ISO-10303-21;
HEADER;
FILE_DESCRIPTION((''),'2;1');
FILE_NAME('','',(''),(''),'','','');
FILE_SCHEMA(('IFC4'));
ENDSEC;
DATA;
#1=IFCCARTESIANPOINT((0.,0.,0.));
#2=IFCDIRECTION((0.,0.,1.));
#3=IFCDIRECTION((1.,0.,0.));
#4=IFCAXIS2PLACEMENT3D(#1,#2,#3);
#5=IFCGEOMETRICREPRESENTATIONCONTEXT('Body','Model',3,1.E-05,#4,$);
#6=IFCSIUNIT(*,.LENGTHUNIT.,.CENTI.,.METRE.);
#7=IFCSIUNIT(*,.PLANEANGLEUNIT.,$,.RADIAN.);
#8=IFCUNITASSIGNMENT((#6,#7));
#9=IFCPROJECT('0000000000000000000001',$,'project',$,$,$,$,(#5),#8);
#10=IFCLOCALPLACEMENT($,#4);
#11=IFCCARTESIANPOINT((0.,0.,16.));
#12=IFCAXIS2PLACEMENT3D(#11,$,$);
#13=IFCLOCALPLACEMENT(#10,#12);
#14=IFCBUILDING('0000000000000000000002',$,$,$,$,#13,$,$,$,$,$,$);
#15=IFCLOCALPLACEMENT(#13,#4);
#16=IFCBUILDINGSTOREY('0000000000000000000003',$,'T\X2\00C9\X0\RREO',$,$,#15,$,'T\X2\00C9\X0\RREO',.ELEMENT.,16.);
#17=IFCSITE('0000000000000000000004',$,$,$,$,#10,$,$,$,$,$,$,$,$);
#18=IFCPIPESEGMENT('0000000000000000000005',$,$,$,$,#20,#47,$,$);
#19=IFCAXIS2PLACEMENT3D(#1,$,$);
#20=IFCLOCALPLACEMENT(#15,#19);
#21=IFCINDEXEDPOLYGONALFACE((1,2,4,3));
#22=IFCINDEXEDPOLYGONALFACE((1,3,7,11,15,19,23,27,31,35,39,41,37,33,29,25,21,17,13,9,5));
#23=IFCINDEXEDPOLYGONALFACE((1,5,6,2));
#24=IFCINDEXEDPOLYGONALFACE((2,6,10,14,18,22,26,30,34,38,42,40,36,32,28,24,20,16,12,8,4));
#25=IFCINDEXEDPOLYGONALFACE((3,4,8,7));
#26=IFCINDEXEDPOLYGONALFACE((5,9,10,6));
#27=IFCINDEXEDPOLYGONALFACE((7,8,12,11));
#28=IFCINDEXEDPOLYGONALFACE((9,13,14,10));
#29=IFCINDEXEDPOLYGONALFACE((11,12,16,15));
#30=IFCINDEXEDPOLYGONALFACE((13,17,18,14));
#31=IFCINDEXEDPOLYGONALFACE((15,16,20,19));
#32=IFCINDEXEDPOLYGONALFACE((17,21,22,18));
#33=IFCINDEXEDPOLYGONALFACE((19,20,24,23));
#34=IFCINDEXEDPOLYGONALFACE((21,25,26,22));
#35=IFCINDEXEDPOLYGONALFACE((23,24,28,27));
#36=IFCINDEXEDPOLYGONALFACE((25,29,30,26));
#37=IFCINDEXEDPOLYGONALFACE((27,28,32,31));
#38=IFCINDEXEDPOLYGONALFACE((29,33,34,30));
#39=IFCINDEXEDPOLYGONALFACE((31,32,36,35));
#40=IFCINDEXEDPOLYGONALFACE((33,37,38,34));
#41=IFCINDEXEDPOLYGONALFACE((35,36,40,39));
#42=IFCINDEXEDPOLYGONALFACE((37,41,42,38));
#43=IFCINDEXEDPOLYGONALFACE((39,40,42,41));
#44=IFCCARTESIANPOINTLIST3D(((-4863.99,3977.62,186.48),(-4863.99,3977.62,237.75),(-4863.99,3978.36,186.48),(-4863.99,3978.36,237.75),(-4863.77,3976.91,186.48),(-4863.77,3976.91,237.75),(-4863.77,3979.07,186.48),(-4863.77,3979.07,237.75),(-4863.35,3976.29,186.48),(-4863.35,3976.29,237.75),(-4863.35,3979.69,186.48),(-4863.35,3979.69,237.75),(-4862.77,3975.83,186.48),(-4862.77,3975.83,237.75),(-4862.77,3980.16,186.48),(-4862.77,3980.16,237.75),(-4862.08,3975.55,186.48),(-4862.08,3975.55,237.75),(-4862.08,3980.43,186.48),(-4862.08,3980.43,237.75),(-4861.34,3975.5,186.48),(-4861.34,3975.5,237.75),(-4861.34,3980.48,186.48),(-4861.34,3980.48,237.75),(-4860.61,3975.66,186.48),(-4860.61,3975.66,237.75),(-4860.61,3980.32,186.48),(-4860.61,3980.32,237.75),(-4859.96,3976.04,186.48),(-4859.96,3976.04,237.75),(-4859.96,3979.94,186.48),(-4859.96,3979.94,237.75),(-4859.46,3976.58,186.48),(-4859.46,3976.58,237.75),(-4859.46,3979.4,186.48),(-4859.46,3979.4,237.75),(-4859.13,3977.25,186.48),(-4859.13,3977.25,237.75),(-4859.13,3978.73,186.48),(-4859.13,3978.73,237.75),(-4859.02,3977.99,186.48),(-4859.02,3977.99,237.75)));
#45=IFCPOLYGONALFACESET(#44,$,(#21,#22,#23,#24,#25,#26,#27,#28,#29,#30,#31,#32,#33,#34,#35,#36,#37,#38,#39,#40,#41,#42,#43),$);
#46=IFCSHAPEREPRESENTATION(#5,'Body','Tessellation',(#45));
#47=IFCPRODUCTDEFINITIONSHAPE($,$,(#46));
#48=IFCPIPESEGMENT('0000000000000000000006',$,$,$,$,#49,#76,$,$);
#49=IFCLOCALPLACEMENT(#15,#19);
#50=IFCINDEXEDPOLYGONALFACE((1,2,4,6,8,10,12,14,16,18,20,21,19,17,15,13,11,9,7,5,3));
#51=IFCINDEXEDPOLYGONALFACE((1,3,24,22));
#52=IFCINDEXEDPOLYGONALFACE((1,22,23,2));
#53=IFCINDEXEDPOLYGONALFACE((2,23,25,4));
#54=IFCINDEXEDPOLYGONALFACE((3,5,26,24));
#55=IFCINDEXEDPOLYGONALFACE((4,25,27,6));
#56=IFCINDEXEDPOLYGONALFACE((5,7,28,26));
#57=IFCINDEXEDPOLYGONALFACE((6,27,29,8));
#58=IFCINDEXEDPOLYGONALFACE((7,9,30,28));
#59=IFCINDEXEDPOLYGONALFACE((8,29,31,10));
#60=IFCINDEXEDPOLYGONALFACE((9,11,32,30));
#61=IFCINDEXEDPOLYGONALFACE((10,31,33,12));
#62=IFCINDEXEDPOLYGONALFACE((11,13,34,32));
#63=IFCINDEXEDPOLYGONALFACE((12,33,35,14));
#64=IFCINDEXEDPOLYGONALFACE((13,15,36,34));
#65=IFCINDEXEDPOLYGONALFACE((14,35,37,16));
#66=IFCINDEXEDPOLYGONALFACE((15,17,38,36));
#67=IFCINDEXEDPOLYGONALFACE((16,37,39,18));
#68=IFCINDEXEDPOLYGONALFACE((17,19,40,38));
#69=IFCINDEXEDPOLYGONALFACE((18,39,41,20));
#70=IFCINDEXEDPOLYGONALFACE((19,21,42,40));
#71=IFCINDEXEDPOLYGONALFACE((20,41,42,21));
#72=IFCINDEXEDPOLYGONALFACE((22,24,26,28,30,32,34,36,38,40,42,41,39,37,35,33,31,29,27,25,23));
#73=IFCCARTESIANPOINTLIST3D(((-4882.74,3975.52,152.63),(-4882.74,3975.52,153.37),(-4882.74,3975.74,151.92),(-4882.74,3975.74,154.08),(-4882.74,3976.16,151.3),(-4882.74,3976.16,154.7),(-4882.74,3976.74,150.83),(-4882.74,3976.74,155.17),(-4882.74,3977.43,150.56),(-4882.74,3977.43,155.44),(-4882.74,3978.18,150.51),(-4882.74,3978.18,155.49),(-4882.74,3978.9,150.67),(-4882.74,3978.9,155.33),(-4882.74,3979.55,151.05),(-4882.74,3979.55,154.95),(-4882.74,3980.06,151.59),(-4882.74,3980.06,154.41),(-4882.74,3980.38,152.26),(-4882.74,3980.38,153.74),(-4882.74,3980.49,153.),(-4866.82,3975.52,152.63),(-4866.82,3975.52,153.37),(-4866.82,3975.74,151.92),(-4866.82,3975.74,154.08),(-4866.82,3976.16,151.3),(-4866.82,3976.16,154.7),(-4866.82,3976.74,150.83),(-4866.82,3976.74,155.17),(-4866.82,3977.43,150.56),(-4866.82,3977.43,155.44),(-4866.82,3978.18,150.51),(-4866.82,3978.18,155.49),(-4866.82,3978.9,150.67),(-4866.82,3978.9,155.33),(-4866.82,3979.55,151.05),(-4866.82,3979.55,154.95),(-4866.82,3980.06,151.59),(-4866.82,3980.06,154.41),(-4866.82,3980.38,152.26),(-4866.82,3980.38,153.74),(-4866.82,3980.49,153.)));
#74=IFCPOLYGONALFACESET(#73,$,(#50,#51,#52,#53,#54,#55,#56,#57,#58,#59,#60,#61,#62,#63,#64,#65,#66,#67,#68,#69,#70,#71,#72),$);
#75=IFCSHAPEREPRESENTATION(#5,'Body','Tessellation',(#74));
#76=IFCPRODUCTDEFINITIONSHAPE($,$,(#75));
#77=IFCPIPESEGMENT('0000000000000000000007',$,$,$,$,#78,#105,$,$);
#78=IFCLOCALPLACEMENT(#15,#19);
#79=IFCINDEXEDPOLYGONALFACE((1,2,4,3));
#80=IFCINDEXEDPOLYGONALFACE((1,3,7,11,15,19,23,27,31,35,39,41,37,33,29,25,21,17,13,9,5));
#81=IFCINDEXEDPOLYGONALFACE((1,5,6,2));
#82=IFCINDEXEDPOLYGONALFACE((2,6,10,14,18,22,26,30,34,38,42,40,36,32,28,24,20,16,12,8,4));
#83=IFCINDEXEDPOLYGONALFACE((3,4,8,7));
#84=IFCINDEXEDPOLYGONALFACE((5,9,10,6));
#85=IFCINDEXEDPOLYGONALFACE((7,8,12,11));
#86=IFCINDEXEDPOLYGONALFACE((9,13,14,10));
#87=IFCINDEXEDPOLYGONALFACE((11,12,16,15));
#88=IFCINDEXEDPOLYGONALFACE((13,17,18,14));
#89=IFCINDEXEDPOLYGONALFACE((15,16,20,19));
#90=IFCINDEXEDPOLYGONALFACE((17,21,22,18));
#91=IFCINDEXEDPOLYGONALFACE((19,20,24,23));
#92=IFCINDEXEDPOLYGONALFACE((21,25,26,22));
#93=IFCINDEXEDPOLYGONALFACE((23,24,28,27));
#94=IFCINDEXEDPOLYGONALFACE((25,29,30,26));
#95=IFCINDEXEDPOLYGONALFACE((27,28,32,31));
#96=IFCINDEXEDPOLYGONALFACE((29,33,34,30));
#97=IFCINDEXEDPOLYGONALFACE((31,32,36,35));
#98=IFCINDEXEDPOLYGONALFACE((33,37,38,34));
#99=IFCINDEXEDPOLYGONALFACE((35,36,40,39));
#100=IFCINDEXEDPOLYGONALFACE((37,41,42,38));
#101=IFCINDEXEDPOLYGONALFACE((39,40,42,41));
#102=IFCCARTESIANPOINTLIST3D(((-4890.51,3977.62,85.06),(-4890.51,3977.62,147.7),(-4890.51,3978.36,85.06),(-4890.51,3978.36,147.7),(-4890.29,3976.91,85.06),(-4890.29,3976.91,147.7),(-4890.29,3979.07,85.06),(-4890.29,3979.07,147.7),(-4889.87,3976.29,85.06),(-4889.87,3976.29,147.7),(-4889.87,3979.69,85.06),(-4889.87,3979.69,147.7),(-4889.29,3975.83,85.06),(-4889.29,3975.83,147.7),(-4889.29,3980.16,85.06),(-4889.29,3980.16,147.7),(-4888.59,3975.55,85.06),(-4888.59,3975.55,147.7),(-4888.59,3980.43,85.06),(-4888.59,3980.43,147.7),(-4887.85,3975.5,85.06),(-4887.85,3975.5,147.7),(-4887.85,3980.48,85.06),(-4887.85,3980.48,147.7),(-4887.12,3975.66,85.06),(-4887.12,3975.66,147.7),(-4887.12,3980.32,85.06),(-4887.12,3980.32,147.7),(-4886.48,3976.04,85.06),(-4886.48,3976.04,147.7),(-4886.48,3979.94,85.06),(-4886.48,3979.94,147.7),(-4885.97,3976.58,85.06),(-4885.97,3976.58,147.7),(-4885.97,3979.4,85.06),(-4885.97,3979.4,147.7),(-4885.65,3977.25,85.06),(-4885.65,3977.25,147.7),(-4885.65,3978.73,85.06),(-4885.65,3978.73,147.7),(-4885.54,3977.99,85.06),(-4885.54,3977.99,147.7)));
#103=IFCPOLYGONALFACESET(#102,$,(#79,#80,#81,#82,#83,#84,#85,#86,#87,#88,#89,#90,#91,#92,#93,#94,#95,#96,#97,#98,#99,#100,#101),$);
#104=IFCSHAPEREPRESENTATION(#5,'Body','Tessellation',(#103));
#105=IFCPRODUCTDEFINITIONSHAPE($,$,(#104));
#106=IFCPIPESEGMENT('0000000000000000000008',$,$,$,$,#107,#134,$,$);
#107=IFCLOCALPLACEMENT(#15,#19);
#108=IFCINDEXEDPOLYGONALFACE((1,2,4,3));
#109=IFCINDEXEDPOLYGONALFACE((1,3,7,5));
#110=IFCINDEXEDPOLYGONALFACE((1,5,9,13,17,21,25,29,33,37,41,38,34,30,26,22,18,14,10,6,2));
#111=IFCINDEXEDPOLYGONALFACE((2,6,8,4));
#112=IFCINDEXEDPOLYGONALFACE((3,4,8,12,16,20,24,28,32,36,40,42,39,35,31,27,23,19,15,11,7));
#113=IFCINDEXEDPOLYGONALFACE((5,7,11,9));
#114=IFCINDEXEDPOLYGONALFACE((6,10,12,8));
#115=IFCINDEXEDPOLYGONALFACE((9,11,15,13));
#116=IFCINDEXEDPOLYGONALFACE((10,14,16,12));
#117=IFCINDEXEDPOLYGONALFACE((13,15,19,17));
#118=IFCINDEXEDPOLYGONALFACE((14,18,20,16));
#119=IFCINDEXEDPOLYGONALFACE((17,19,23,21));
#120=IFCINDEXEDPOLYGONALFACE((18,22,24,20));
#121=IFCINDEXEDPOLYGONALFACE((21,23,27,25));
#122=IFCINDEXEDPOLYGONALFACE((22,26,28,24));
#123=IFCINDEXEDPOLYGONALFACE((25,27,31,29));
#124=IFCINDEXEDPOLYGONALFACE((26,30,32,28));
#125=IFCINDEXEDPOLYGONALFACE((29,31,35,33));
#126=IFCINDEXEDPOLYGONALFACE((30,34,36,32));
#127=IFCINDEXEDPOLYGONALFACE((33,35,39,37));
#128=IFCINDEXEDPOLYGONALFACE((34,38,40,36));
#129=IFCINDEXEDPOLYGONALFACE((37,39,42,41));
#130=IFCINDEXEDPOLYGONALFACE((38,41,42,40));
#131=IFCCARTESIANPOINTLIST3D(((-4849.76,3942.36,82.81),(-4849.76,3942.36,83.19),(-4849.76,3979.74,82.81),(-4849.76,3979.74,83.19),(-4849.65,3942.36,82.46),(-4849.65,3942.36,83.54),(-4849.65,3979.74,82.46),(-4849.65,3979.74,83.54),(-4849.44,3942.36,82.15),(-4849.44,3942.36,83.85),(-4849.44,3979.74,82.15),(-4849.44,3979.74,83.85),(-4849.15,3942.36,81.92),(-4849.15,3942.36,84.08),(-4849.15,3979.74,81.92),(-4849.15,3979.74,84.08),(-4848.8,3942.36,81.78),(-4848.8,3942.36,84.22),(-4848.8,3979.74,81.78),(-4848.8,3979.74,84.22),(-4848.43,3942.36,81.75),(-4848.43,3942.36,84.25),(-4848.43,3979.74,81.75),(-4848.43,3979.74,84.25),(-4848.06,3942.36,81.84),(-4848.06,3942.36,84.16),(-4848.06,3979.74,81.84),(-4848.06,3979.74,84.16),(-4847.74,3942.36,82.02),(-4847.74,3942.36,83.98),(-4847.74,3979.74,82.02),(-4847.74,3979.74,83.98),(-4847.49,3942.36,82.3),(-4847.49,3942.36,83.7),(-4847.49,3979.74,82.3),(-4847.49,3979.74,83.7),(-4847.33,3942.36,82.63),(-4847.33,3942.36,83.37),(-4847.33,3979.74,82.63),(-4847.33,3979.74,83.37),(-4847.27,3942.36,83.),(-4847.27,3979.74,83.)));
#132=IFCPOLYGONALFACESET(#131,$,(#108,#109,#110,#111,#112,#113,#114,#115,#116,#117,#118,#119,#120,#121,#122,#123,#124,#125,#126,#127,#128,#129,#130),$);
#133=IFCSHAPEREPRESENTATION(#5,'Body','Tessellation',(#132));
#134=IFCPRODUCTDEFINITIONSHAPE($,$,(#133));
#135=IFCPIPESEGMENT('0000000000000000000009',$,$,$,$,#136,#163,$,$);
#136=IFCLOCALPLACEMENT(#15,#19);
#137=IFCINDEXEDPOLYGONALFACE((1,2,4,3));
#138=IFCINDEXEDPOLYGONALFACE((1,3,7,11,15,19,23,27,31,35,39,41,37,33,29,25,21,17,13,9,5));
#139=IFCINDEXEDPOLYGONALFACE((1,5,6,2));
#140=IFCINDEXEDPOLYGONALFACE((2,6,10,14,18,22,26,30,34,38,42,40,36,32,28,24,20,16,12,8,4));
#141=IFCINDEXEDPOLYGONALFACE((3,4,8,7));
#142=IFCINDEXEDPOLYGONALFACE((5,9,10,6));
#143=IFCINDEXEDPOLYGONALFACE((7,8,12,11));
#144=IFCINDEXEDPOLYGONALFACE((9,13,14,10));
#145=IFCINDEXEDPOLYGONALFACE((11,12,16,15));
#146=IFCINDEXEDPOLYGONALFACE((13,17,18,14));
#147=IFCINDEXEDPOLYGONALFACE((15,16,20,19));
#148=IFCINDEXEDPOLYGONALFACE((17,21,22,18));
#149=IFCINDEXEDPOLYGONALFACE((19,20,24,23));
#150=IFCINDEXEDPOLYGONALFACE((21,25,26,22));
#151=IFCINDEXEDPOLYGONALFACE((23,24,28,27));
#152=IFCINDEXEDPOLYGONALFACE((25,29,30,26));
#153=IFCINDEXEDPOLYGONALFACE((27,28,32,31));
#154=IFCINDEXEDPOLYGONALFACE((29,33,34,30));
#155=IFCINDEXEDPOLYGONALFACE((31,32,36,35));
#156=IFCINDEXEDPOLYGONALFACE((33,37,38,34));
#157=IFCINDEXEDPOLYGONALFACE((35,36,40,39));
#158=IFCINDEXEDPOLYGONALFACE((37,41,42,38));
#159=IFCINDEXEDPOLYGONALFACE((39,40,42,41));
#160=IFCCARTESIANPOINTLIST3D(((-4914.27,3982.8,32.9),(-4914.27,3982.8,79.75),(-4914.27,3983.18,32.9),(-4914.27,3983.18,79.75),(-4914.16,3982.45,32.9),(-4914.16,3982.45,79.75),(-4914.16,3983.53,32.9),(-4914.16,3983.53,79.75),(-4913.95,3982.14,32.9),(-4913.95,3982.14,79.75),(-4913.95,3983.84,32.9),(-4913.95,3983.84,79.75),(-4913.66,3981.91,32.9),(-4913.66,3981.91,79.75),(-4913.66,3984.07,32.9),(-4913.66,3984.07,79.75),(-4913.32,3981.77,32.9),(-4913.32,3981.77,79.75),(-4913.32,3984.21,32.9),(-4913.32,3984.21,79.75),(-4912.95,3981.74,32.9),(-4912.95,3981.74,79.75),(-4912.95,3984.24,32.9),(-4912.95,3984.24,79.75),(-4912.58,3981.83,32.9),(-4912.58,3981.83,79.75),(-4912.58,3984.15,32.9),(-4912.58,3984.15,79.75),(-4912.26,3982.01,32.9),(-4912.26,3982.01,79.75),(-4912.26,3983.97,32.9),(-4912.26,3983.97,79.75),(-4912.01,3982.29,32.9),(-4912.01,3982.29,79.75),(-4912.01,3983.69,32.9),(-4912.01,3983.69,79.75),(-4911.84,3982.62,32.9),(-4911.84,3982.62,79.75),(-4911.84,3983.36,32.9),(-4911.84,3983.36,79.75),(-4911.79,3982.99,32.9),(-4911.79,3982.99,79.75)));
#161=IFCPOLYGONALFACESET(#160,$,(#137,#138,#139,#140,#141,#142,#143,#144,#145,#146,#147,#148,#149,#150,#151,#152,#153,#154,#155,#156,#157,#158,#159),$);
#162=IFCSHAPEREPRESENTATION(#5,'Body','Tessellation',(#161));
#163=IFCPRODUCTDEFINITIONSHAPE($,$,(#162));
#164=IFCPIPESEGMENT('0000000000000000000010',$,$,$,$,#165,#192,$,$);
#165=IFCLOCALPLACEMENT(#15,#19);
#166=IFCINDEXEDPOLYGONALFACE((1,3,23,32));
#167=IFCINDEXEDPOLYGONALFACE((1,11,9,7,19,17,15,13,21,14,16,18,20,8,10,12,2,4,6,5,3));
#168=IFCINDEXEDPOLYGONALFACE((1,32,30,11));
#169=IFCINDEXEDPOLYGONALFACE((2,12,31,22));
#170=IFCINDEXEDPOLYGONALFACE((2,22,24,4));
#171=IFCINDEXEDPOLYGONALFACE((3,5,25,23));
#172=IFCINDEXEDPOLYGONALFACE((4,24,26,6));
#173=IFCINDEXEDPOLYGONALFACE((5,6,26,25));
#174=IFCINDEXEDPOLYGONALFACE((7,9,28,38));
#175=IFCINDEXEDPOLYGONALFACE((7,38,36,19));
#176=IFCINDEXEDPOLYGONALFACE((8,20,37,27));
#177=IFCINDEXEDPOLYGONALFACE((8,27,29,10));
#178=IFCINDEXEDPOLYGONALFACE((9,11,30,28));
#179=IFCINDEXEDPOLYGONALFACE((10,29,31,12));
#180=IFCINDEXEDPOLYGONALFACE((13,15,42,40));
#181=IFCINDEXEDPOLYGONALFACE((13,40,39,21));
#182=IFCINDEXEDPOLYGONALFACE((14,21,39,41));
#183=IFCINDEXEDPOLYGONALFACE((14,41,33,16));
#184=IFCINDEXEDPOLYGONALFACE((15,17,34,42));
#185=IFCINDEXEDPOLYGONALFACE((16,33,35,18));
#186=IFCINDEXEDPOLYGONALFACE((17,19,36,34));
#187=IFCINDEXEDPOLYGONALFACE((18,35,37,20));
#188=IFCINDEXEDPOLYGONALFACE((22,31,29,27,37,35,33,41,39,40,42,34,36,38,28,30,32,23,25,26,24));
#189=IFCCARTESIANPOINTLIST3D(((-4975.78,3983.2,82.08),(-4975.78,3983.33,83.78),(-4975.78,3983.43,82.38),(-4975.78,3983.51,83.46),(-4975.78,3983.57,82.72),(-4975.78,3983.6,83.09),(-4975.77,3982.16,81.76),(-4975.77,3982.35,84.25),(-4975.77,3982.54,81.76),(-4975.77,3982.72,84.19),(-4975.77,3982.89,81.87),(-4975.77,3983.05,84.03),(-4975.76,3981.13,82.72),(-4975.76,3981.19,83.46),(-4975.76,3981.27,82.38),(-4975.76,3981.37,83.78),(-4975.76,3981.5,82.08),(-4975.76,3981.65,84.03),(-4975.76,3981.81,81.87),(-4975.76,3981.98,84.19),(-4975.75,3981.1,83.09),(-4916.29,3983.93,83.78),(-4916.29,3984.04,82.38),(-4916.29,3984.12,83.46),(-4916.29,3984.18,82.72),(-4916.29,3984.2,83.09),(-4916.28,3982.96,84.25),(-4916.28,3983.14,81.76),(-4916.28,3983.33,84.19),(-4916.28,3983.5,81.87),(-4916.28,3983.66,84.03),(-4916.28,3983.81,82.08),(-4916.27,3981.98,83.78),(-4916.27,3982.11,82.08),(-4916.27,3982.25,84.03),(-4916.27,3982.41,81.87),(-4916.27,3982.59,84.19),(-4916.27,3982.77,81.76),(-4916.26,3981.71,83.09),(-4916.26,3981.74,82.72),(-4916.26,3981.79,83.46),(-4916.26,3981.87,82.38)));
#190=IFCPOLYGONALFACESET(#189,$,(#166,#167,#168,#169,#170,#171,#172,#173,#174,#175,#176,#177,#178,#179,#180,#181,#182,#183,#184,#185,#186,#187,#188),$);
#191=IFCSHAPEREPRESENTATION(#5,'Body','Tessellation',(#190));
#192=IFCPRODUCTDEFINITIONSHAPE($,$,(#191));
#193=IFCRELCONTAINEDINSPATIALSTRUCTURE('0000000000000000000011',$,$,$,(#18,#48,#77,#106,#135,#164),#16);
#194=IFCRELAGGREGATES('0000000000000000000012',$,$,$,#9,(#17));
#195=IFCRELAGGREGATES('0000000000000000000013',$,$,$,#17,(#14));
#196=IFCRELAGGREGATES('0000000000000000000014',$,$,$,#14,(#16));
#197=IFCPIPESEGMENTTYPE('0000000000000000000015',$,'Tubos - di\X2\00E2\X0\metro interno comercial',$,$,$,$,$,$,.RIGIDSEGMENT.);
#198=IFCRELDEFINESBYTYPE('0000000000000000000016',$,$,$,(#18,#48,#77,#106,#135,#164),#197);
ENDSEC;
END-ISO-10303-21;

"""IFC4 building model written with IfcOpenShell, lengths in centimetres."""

from ifc_helpers import new_model, si_unit, frame, origin_with_axes, origin_2d_with_axis, place, context, project, spatial, circle, extrude, type_object, element, save


model = new_model("IFC4")

# Units and contexts
model_context = context("Model", 3, precision=1e-05, world=origin_with_axes(), identifier="Body")
ifc_project = project(units=[si_unit("LENGTHUNIT", "METRE", prefix="CENTI"), si_unit("PLANEANGLEUNIT", "RADIAN")], contexts=[model_context])

# Site, building, storey
site_placement = place(None, origin_with_axes())
site = spatial("IfcSite", under=ifc_project, at=site_placement)
building_placement = place(site_placement, frame((0.0, 0.0, 16.0)))
building = spatial("IfcBuilding", under=site, at=building_placement)
storey_placement = place(building_placement, origin_with_axes())
storey = spatial("IfcBuildingStorey", under=building, at=storey_placement, Name="TÉRREO", LongName="TÉRREO", CompositionType="ELEMENT", Elevation=16.0)

# Pipe segments
pipe_segment_type = type_object("IfcPipeSegmentType", Name="Tubos - diâmetro interno comercial", PredefinedType="RIGIDSEGMENT")
pipe_segment_1_placement = place(storey_placement, frame((-4861.52, 3977.99, 237.75), z_axis=(0.0, 0.0, 1.0), x_axis=(1.0, 0.0, 0.0)))
element("IfcPipeSegment", 1, at=pipe_segment_1_placement, inside=storey, type_object=pipe_segment_type, context=model_context, shape_type="SolidModel", body=[
    extrude(circle(Radius=2.5, at=origin_2d_with_axis()), frame((0.0, 0.0, 0.0), z_axis=(0.0, 0.0, -1.0), x_axis=(1.0, 0.0, 0.0)), (0.0, 0.0, 1.0), 51.27),
])
pipe_segment_2_placement = place(storey_placement, frame((-4874.78, 3977.99, 155.5), z_axis=(0.0, 0.0, 1.0), x_axis=(1.0, 0.0, 0.0)))
element("IfcPipeSegment", 2, at=pipe_segment_2_placement, inside=storey, type_object=pipe_segment_type, context=model_context, shape_type="SolidModel", body=[
    extrude(circle(Radius=2.5, at=origin_2d_with_axis()), frame((7.96, 0.0, -2.5), z_axis=(-1.0, 0.0, 0.0), x_axis=(0.0, 1.0, 0.0)), (0.0, 0.0, 1.0), 15.91),
])
pipe_segment_3_placement = place(storey_placement, frame((-4888.04, 3977.99, 147.7), z_axis=(0.0, 0.0, 1.0), x_axis=(1.0, 0.0, 0.0)))
element("IfcPipeSegment", 3, at=pipe_segment_3_placement, inside=storey, type_object=pipe_segment_type, context=model_context, shape_type="SolidModel", body=[
    extrude(circle(Radius=2.5, at=origin_2d_with_axis()), frame((0.0, 0.0, 0.0), z_axis=(0.0, 0.0, -1.0), x_axis=(1.0, 0.0, 0.0)), (0.0, 0.0, 1.0), 62.64),
])
pipe_segment_4_placement = place(storey_placement, frame((-4848.52, 3961.05, 84.25), z_axis=(0.0, 0.0, 1.0), x_axis=(1.0, 0.0, 0.0)))
element("IfcPipeSegment", 4, at=pipe_segment_4_placement, inside=storey, type_object=pipe_segment_type, context=model_context, shape_type="SolidModel", body=[
    extrude(circle(Radius=1.25, at=origin_2d_with_axis()), frame((0.0, -18.69, -1.25), z_axis=(0.0, 1.0, 0.0), x_axis=(1.0, 0.0, 0.0)), (0.0, 0.0, 1.0), 37.38),
])
pipe_segment_5_placement = place(storey_placement, frame((-4913.04, 3982.99, 79.75), z_axis=(0.0, 0.0, 1.0), x_axis=(1.0, 0.0, 0.0)))
element("IfcPipeSegment", 5, at=pipe_segment_5_placement, inside=storey, type_object=pipe_segment_type, context=model_context, shape_type="SolidModel", body=[
    extrude(circle(Radius=1.25, at=origin_2d_with_axis()), frame((0.0, 0.0, 0.0), z_axis=(0.0, 0.0, -1.0), x_axis=(1.0, 0.0, 0.0)), (0.0, 0.0, 1.0), 46.85),
])
pipe_segment_6_placement = place(storey_placement, frame((-4946.02, 3982.65, 84.25), z_axis=(0.0, 0.0, 1.0), x_axis=(1.0, 0.0, 0.0)))
element("IfcPipeSegment", 6, at=pipe_segment_6_placement, inside=storey, type_object=pipe_segment_type, context=model_context, shape_type="SolidModel", body=[
    extrude(circle(Radius=1.25, at=origin_2d_with_axis()), frame((29.75, 0.3, -1.25), z_axis=(-1.0, -0.0102, 0.0), x_axis=(0.0, 0.0, 1.0)), (0.0, 0.0, 1.0), 59.49),
])

save(model, "model.ifc")
